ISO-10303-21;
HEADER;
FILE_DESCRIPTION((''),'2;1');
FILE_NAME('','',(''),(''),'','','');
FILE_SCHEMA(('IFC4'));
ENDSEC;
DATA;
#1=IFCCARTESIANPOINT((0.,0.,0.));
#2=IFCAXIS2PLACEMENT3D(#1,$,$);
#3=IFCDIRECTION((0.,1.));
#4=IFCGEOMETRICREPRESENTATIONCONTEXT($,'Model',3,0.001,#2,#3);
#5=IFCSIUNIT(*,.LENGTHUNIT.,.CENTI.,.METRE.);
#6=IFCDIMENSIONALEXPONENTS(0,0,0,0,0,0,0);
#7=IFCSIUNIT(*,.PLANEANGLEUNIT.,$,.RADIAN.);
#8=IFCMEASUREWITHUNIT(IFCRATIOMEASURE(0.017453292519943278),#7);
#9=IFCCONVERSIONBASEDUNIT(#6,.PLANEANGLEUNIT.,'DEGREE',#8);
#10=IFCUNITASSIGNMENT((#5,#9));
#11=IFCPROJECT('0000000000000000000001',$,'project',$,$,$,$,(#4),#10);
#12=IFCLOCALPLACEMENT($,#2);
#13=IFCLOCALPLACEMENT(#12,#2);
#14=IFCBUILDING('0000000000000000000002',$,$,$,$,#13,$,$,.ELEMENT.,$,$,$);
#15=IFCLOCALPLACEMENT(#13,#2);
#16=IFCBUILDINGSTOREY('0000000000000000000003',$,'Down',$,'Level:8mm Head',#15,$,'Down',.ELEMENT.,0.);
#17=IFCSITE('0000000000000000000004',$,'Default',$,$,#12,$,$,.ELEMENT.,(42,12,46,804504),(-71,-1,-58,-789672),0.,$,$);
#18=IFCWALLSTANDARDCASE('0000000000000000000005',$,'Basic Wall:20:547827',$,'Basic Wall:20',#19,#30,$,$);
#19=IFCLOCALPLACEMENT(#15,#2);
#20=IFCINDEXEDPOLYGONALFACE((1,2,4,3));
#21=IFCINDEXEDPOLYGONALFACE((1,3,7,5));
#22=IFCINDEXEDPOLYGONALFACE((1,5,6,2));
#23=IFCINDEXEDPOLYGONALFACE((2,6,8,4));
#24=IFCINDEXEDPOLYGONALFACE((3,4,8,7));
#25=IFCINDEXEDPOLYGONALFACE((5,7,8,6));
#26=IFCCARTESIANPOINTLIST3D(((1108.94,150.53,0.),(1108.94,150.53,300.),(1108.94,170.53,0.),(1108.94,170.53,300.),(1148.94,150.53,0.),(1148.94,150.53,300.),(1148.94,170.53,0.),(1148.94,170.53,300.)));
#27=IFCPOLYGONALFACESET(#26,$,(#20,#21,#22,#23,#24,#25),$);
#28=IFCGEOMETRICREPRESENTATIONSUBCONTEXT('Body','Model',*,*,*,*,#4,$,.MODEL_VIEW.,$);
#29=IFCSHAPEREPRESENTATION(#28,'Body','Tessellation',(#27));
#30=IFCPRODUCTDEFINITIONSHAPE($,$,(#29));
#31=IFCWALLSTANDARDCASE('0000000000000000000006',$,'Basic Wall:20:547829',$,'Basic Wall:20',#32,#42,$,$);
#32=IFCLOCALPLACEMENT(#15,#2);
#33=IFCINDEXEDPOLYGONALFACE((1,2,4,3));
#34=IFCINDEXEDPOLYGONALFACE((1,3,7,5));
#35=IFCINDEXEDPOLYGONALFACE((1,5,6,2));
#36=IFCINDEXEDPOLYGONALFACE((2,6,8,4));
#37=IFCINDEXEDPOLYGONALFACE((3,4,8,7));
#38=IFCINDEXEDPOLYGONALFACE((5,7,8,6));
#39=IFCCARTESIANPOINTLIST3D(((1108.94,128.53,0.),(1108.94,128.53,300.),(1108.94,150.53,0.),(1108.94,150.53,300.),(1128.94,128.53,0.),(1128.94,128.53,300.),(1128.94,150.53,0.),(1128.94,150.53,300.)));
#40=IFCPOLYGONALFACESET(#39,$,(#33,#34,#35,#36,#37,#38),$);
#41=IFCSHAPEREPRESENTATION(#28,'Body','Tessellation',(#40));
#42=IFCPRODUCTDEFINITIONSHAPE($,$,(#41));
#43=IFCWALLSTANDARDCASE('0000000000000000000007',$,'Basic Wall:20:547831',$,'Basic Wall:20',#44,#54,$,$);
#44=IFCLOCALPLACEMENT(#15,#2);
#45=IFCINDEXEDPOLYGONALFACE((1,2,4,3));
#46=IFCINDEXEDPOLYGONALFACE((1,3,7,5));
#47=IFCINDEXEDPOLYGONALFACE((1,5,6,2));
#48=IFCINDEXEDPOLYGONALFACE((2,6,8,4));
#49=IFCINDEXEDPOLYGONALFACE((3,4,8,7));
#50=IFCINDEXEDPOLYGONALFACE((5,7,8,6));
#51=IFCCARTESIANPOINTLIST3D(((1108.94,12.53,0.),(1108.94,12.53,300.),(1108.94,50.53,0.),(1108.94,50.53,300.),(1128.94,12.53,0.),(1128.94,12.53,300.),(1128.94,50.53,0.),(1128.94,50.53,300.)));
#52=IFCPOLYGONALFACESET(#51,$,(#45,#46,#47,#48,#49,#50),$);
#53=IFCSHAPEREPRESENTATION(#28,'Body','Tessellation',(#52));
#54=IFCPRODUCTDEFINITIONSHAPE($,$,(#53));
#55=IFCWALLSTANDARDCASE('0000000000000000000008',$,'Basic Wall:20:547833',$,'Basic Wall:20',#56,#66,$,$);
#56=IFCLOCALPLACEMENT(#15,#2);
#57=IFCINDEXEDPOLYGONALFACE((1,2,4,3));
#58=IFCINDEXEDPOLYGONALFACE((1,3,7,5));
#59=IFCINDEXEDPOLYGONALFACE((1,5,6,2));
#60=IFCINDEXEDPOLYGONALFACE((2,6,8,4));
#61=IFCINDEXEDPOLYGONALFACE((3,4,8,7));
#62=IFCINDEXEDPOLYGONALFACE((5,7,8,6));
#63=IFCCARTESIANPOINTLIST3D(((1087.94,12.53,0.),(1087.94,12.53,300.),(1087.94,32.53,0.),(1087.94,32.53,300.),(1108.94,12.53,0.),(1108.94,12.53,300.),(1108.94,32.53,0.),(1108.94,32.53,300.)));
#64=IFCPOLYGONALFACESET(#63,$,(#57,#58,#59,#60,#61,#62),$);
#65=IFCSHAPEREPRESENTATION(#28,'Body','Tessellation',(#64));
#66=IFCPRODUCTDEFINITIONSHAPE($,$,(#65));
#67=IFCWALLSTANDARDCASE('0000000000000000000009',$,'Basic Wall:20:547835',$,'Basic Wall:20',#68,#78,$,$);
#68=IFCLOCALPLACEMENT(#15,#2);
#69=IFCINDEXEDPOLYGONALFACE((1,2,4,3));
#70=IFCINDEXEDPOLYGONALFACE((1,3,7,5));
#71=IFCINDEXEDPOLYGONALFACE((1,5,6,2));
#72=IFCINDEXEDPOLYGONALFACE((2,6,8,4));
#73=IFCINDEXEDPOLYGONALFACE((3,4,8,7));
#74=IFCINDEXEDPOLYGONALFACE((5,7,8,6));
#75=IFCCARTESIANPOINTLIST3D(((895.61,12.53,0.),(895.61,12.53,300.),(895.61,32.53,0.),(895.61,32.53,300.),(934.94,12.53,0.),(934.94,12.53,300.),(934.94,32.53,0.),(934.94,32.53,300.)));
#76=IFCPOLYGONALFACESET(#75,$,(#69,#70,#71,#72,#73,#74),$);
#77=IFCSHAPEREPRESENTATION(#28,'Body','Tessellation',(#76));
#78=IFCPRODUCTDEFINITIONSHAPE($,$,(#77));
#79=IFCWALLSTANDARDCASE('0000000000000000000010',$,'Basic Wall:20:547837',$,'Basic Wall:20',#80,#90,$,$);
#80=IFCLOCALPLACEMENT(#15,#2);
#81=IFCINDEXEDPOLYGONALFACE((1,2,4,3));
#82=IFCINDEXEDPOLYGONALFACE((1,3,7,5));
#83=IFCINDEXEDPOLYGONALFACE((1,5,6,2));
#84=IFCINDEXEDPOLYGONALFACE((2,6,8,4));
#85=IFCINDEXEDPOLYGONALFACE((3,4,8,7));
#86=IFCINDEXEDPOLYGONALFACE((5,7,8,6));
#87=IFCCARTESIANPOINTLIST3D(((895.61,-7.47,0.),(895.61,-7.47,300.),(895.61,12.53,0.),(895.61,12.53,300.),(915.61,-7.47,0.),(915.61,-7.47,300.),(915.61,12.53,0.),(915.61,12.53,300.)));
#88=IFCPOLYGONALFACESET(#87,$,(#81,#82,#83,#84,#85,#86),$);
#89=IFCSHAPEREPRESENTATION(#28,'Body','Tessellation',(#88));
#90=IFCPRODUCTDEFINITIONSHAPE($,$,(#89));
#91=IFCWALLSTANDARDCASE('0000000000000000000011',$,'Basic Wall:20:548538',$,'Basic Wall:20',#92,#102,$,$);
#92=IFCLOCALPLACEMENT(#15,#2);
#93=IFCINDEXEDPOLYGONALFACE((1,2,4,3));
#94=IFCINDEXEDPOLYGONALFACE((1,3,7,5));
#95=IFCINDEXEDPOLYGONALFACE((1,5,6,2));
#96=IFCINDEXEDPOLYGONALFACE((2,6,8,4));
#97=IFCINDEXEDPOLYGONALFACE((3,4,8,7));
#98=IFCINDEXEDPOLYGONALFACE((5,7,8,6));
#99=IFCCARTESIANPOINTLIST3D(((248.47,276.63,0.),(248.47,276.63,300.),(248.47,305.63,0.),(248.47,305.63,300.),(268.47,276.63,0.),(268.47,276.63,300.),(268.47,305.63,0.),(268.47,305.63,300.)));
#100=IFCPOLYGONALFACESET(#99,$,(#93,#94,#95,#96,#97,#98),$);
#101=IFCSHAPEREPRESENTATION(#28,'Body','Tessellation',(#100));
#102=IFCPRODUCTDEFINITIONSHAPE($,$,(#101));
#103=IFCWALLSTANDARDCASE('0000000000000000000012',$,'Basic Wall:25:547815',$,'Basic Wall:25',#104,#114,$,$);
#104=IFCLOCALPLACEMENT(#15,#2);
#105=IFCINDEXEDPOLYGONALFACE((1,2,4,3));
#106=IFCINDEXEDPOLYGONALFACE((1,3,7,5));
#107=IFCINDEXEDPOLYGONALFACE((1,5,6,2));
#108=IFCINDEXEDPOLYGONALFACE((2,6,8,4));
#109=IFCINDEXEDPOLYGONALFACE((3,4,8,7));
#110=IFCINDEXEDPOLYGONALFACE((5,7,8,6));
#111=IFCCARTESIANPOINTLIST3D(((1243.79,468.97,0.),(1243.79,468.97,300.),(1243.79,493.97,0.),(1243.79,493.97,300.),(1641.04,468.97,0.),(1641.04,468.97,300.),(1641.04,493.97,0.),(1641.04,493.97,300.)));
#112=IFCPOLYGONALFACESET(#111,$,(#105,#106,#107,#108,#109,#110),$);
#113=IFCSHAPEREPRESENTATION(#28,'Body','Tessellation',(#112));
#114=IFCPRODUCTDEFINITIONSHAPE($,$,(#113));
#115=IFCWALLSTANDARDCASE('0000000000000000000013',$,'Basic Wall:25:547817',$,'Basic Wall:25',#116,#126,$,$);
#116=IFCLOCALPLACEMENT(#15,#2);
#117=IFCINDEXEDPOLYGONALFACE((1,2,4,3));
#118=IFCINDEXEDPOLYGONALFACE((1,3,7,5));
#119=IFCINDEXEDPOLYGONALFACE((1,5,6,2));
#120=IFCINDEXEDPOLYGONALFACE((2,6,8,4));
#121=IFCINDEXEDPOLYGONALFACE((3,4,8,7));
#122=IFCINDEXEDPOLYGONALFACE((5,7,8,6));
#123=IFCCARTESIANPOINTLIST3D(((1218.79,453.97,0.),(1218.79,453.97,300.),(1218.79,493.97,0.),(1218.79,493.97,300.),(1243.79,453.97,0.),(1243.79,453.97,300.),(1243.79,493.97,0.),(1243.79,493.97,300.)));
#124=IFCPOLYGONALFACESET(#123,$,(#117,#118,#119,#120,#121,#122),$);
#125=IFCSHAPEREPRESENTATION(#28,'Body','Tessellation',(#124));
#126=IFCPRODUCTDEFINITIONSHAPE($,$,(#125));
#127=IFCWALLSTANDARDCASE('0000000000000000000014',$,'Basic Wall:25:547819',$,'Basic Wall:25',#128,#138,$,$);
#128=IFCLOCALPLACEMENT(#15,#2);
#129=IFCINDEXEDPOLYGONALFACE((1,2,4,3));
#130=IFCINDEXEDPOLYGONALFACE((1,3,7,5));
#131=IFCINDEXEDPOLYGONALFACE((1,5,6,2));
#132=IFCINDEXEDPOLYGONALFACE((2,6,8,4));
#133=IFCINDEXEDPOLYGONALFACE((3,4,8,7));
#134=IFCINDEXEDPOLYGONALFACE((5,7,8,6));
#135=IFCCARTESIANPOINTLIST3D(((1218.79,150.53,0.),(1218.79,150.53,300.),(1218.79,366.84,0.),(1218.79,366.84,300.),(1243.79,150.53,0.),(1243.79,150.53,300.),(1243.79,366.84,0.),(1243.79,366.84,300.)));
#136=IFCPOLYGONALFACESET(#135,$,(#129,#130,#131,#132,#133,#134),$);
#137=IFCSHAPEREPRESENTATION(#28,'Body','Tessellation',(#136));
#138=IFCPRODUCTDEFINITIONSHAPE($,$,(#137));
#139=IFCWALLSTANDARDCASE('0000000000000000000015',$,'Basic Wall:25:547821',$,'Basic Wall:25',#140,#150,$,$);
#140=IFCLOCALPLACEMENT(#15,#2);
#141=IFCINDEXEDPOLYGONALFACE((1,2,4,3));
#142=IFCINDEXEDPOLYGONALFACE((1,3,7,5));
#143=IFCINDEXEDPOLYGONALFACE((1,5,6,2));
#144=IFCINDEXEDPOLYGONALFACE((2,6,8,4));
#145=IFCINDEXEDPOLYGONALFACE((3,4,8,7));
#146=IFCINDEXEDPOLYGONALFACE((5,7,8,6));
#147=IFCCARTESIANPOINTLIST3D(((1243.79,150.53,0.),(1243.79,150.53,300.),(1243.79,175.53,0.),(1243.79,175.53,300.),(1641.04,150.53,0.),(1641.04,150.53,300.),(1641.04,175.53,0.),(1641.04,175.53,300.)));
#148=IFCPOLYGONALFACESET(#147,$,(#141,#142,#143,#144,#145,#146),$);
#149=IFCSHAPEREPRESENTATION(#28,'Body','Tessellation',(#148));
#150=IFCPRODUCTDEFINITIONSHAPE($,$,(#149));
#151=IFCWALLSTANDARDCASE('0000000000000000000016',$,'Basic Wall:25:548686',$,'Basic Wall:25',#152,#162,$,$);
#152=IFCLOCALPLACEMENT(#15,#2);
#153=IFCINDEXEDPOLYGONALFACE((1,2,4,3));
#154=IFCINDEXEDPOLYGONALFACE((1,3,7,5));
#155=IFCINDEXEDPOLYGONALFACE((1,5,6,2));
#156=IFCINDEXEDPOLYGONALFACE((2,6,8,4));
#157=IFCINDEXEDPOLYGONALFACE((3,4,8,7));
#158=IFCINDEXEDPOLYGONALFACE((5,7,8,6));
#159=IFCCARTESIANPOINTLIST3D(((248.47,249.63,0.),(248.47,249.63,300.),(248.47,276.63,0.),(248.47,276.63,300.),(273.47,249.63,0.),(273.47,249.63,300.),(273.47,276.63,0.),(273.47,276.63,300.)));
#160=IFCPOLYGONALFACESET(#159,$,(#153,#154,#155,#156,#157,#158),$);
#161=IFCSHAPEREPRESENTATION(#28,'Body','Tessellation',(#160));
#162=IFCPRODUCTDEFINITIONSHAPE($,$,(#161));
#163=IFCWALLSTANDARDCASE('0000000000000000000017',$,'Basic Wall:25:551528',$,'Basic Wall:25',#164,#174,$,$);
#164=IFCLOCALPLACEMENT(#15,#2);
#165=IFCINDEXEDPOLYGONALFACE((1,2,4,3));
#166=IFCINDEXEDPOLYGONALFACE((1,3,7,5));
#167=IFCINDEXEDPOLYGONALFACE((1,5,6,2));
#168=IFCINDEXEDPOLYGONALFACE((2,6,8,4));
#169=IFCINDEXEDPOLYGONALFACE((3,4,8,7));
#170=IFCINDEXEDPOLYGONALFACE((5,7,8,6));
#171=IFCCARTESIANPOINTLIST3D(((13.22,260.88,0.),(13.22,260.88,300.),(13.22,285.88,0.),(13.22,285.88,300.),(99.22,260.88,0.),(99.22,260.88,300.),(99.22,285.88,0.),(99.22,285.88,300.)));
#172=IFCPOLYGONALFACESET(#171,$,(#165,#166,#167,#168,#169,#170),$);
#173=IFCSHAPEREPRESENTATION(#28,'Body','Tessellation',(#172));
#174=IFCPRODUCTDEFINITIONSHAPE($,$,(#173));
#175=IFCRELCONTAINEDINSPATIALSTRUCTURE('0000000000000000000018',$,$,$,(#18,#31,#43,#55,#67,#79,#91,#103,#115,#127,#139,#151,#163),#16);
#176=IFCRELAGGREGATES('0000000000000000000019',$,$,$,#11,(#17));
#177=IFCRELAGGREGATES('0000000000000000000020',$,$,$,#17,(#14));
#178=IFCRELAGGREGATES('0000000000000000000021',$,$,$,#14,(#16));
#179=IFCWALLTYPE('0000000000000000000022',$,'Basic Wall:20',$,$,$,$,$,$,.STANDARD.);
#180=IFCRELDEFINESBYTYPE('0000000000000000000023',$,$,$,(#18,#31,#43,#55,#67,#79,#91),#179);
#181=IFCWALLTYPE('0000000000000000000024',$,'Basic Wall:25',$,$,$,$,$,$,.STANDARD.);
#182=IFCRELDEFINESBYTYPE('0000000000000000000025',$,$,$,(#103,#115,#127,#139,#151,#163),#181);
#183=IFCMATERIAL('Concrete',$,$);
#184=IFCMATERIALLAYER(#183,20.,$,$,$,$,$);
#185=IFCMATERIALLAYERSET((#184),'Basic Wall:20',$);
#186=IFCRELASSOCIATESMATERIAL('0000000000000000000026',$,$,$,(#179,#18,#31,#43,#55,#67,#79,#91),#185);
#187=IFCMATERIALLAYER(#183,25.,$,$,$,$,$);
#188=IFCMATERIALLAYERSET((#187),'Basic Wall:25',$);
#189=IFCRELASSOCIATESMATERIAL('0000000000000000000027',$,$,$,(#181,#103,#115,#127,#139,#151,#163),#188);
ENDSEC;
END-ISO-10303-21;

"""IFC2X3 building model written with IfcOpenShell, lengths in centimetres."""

from ifc_helpers import new_model, entity, si_unit, converted_unit, direction, frame, frame_2d, origin, place, context, subcontext, project, spatial, rectangle, extrude, material, layer, layer_set, layer_usage, type_object, element, save


model = new_model("IFC2X3")

# Units and contexts
model_context = context("Model", 3, precision=0.001, world=origin(), true_north=direction((0.0, 1.0)))
body_context = subcontext(model_context, "Body", "Model", "MODEL_VIEW")
ifc_project = project(units=[si_unit("LENGTHUNIT", "METRE", prefix="CENTI"), converted_unit("PLANEANGLEUNIT", "DEGREE", entity("IfcRatioMeasure", 0.017453292519943278), si_unit("PLANEANGLEUNIT", "RADIAN"), dimensions=[0, 0, 0, 0, 0, 0, 0])], contexts=[model_context])

# Site, building, storey
site_placement = place(None, origin())
site = spatial("IfcSite", under=ifc_project, at=site_placement, Name="Default", CompositionType="ELEMENT", RefLatitude=(42, 12, 46, 804504), RefLongitude=(-71, -1, -58, -789672), RefElevation=0.0)
building_placement = place(site_placement, origin())
building = spatial("IfcBuilding", under=site, at=building_placement, CompositionType="ELEMENT")
storey_placement = place(building_placement, origin())
storey = spatial("IfcBuildingStorey", under=building, at=storey_placement, Name="Down", ObjectType="Level:8mm Head", LongName="Down", CompositionType="ELEMENT", Elevation=0.0)

# Shared definitions
ifc_material = material(Name="Concrete")

# Walls
ifc_layer_1 = layer(ifc_material, 20.0)
ifc_layer_set_1 = layer_set([ifc_layer_1], Name="Basic Wall:20")
wall_type_1 = type_object("IfcWallType", Name="Basic Wall:20", PredefinedType="STANDARD", material=ifc_layer_set_1)
ifc_layer_usage_1 = layer_usage(ifc_layer_set_1, "AXIS2", "NEGATIVE", 10.0)
wall_1_placement = place(storey_placement, frame((1148.94, 160.53, 0.0), z_axis=(0.0, 0.0, 1.0), x_axis=(-1.0, 0.0, 0.0)))
element("IfcWallStandardCase", 1, at=wall_1_placement, inside=storey, type_object=wall_type_1, material=ifc_layer_usage_1, Name="Basic Wall:20:547827", ObjectType="Basic Wall:20", context=body_context, shape_type="SweptSolid", body=[
    extrude(rectangle(XDim=40.0, YDim=20.0, at=frame_2d((20.0, 0.0), x_axis=(-1.0, 0.0))), origin(), (0.0, 0.0, 1.0), 300.0),
])
ifc_layer_usage_2 = layer_usage(ifc_layer_set_1, "AXIS2", "POSITIVE", -10.0)
wall_2_placement = place(storey_placement, frame((1118.94, 150.53, 0.0), z_axis=(0.0, 0.0, 1.0), x_axis=(0.0, -1.0, 0.0)))
element("IfcWallStandardCase", 2, at=wall_2_placement, inside=storey, type_object=wall_type_1, material=ifc_layer_usage_2, Name="Basic Wall:20:547829", ObjectType="Basic Wall:20", context=body_context, shape_type="SweptSolid", body=[
    extrude(rectangle(XDim=22.0, YDim=20.0, at=frame_2d((11.0, 0.0), x_axis=(-1.0, 0.0))), origin(), (0.0, 0.0, 1.0), 300.0),
])
ifc_layer_usage_3 = layer_usage(ifc_layer_set_1, "AXIS2", "POSITIVE", -10.0)
wall_3_placement = place(storey_placement, frame((1118.94, 50.53, 0.0), z_axis=(0.0, 0.0, 1.0), x_axis=(0.0, -1.0, 0.0)))
element("IfcWallStandardCase", 3, at=wall_3_placement, inside=storey, type_object=wall_type_1, material=ifc_layer_usage_3, Name="Basic Wall:20:547831", ObjectType="Basic Wall:20", context=body_context, shape_type="SweptSolid", body=[
    extrude(rectangle(XDim=38.0, YDim=20.0, at=frame_2d((19.0, 0.0), x_axis=(-1.0, 0.0))), origin(), (0.0, 0.0, 1.0), 300.0),
])
ifc_layer_usage_4 = layer_usage(ifc_layer_set_1, "AXIS2", "NEGATIVE", 10.0)
wall_4_placement = place(storey_placement, frame((1108.94, 22.53, 0.0), z_axis=(0.0, 0.0, 1.0), x_axis=(-1.0, 0.0, 0.0)))
element("IfcWallStandardCase", 4, at=wall_4_placement, inside=storey, type_object=wall_type_1, material=ifc_layer_usage_4, Name="Basic Wall:20:547833", ObjectType="Basic Wall:20", context=body_context, shape_type="SweptSolid", body=[
    extrude(rectangle(XDim=21.0, YDim=20.0, at=frame_2d((10.5, 0.0), x_axis=(-1.0, 0.0))), origin(), (0.0, 0.0, 1.0), 300.0),
])
ifc_layer_usage_5 = layer_usage(ifc_layer_set_1, "AXIS2", "NEGATIVE", 10.0)
wall_5_placement = place(storey_placement, frame((934.94, 22.53, 0.0), z_axis=(0.0, 0.0, 1.0), x_axis=(-1.0, 0.0, 0.0)))
element("IfcWallStandardCase", 5, at=wall_5_placement, inside=storey, type_object=wall_type_1, material=ifc_layer_usage_5, Name="Basic Wall:20:547835", ObjectType="Basic Wall:20", context=body_context, shape_type="SweptSolid", body=[
    extrude(rectangle(XDim=39.33, YDim=20.0, at=frame_2d((19.67, 0.0), x_axis=(-1.0, 0.0))), origin(), (0.0, 0.0, 1.0), 300.0),
])
ifc_layer_usage_6 = layer_usage(ifc_layer_set_1, "AXIS2", "POSITIVE", -10.0)
wall_6_placement = place(storey_placement, frame((905.61, 12.53, 0.0), z_axis=(0.0, 0.0, 1.0), x_axis=(0.0, -1.0, 0.0)))
element("IfcWallStandardCase", 6, at=wall_6_placement, inside=storey, type_object=wall_type_1, material=ifc_layer_usage_6, Name="Basic Wall:20:547837", ObjectType="Basic Wall:20", context=body_context, shape_type="SweptSolid", body=[
    extrude(rectangle(XDim=20.0, YDim=20.0, at=frame_2d((10.0, 0.0), x_axis=(-1.0, 0.0))), origin(), (0.0, 0.0, 1.0), 300.0),
])
ifc_layer_usage_7 = layer_usage(ifc_layer_set_1, "AXIS2", "NEGATIVE", 10.0)
wall_7_placement = place(storey_placement, frame((258.47, 276.63, 0.0), z_axis=(0.0, 0.0, 1.0), x_axis=(0.0, 1.0, 0.0)))
element("IfcWallStandardCase", 7, at=wall_7_placement, inside=storey, type_object=wall_type_1, material=ifc_layer_usage_7, Name="Basic Wall:20:548538", ObjectType="Basic Wall:20", context=body_context, shape_type="SweptSolid", body=[
    extrude(rectangle(XDim=29.0, YDim=20.0, at=frame_2d((14.5, 0.0), x_axis=(-1.0, 0.0))), origin(), (0.0, 0.0, 1.0), 300.0),
])
ifc_layer_2 = layer(ifc_material, 25.0)
ifc_layer_set_2 = layer_set([ifc_layer_2], Name="Basic Wall:25")
ifc_layer_usage_8 = layer_usage(ifc_layer_set_2, "AXIS2", "NEGATIVE", 12.5)
wall_type_2 = type_object("IfcWallType", Name="Basic Wall:25", PredefinedType="STANDARD", material=ifc_layer_set_2)
wall_8_placement = place(storey_placement, frame((1243.79, 481.47, 0.0)))
element("IfcWallStandardCase", 8, at=wall_8_placement, inside=storey, type_object=wall_type_2, material=ifc_layer_usage_8, Name="Basic Wall:25:547815", ObjectType="Basic Wall:25", context=body_context, shape_type="SweptSolid", body=[
    extrude(rectangle(XDim=397.26, YDim=25.0, at=frame_2d((198.63, 0.0), x_axis=(-1.0, 0.0))), origin(), (0.0, 0.0, 1.0), 300.0),
])
ifc_layer_usage_9 = layer_usage(ifc_layer_set_2, "AXIS2", "POSITIVE", -12.5)
wall_9_placement = place(storey_placement, frame((1231.29, 493.97, 0.0), z_axis=(0.0, 0.0, 1.0), x_axis=(0.0, -1.0, 0.0)))
element("IfcWallStandardCase", 9, at=wall_9_placement, inside=storey, type_object=wall_type_2, material=ifc_layer_usage_9, Name="Basic Wall:25:547817", ObjectType="Basic Wall:25", context=body_context, shape_type="SweptSolid", body=[
    extrude(rectangle(XDim=40.0, YDim=25.0, at=frame_2d((20.0, 0.0), x_axis=(-1.0, 0.0))), origin(), (0.0, 0.0, 1.0), 300.0),
])
ifc_layer_usage_10 = layer_usage(ifc_layer_set_2, "AXIS2", "POSITIVE", -12.5)
wall_10_placement = place(storey_placement, frame((1231.29, 366.84, 0.0), z_axis=(0.0, 0.0, 1.0), x_axis=(0.0, -1.0, 0.0)))
element("IfcWallStandardCase", 10, at=wall_10_placement, inside=storey, type_object=wall_type_2, material=ifc_layer_usage_10, Name="Basic Wall:25:547819", ObjectType="Basic Wall:25", context=body_context, shape_type="SweptSolid", body=[
    extrude(rectangle(XDim=216.31, YDim=25.0, at=frame_2d((108.15, 0.0), x_axis=(-1.0, 0.0))), origin(), (0.0, 0.0, 1.0), 300.0),
])
ifc_layer_usage_11 = layer_usage(ifc_layer_set_2, "AXIS2", "POSITIVE", -12.5)
wall_11_placement = place(storey_placement, frame((1243.79, 163.03, 0.0)))
element("IfcWallStandardCase", 11, at=wall_11_placement, inside=storey, type_object=wall_type_2, material=ifc_layer_usage_11, Name="Basic Wall:25:547821", ObjectType="Basic Wall:25", context=body_context, shape_type="SweptSolid", body=[
    extrude(rectangle(XDim=397.26, YDim=25.0, at=frame_2d((198.63, 0.0), x_axis=(-1.0, 0.0))), origin(), (0.0, 0.0, 1.0), 300.0),
])
ifc_layer_usage_12 = layer_usage(ifc_layer_set_2, "AXIS2", "POSITIVE", -12.5)
wall_12_placement = place(storey_placement, frame((260.97, 276.63, 0.0), z_axis=(0.0, 0.0, 1.0), x_axis=(0.0, -1.0, 0.0)))
element("IfcWallStandardCase", 12, at=wall_12_placement, inside=storey, type_object=wall_type_2, material=ifc_layer_usage_12, Name="Basic Wall:25:548686", ObjectType="Basic Wall:25", context=body_context, shape_type="SweptSolid", body=[
    extrude(rectangle(XDim=27.0, YDim=25.0, at=frame_2d((13.5, 0.0), x_axis=(-1.0, 0.0))), origin(), (0.0, 0.0, 1.0), 300.0),
])
ifc_layer_usage_13 = layer_usage(ifc_layer_set_2, "AXIS2", "NEGATIVE", 12.5)
wall_13_placement = place(storey_placement, frame((13.22, 273.38, 0.0)))
element("IfcWallStandardCase", 13, at=wall_13_placement, inside=storey, type_object=wall_type_2, material=ifc_layer_usage_13, Name="Basic Wall:25:551528", ObjectType="Basic Wall:25", context=body_context, shape_type="SweptSolid", body=[
    extrude(rectangle(XDim=86.0, YDim=25.0, at=frame_2d((43.0, 0.0), x_axis=(-1.0, 0.0))), origin(), (0.0, 0.0, 1.0), 300.0),
])

save(model, "model.ifc")
